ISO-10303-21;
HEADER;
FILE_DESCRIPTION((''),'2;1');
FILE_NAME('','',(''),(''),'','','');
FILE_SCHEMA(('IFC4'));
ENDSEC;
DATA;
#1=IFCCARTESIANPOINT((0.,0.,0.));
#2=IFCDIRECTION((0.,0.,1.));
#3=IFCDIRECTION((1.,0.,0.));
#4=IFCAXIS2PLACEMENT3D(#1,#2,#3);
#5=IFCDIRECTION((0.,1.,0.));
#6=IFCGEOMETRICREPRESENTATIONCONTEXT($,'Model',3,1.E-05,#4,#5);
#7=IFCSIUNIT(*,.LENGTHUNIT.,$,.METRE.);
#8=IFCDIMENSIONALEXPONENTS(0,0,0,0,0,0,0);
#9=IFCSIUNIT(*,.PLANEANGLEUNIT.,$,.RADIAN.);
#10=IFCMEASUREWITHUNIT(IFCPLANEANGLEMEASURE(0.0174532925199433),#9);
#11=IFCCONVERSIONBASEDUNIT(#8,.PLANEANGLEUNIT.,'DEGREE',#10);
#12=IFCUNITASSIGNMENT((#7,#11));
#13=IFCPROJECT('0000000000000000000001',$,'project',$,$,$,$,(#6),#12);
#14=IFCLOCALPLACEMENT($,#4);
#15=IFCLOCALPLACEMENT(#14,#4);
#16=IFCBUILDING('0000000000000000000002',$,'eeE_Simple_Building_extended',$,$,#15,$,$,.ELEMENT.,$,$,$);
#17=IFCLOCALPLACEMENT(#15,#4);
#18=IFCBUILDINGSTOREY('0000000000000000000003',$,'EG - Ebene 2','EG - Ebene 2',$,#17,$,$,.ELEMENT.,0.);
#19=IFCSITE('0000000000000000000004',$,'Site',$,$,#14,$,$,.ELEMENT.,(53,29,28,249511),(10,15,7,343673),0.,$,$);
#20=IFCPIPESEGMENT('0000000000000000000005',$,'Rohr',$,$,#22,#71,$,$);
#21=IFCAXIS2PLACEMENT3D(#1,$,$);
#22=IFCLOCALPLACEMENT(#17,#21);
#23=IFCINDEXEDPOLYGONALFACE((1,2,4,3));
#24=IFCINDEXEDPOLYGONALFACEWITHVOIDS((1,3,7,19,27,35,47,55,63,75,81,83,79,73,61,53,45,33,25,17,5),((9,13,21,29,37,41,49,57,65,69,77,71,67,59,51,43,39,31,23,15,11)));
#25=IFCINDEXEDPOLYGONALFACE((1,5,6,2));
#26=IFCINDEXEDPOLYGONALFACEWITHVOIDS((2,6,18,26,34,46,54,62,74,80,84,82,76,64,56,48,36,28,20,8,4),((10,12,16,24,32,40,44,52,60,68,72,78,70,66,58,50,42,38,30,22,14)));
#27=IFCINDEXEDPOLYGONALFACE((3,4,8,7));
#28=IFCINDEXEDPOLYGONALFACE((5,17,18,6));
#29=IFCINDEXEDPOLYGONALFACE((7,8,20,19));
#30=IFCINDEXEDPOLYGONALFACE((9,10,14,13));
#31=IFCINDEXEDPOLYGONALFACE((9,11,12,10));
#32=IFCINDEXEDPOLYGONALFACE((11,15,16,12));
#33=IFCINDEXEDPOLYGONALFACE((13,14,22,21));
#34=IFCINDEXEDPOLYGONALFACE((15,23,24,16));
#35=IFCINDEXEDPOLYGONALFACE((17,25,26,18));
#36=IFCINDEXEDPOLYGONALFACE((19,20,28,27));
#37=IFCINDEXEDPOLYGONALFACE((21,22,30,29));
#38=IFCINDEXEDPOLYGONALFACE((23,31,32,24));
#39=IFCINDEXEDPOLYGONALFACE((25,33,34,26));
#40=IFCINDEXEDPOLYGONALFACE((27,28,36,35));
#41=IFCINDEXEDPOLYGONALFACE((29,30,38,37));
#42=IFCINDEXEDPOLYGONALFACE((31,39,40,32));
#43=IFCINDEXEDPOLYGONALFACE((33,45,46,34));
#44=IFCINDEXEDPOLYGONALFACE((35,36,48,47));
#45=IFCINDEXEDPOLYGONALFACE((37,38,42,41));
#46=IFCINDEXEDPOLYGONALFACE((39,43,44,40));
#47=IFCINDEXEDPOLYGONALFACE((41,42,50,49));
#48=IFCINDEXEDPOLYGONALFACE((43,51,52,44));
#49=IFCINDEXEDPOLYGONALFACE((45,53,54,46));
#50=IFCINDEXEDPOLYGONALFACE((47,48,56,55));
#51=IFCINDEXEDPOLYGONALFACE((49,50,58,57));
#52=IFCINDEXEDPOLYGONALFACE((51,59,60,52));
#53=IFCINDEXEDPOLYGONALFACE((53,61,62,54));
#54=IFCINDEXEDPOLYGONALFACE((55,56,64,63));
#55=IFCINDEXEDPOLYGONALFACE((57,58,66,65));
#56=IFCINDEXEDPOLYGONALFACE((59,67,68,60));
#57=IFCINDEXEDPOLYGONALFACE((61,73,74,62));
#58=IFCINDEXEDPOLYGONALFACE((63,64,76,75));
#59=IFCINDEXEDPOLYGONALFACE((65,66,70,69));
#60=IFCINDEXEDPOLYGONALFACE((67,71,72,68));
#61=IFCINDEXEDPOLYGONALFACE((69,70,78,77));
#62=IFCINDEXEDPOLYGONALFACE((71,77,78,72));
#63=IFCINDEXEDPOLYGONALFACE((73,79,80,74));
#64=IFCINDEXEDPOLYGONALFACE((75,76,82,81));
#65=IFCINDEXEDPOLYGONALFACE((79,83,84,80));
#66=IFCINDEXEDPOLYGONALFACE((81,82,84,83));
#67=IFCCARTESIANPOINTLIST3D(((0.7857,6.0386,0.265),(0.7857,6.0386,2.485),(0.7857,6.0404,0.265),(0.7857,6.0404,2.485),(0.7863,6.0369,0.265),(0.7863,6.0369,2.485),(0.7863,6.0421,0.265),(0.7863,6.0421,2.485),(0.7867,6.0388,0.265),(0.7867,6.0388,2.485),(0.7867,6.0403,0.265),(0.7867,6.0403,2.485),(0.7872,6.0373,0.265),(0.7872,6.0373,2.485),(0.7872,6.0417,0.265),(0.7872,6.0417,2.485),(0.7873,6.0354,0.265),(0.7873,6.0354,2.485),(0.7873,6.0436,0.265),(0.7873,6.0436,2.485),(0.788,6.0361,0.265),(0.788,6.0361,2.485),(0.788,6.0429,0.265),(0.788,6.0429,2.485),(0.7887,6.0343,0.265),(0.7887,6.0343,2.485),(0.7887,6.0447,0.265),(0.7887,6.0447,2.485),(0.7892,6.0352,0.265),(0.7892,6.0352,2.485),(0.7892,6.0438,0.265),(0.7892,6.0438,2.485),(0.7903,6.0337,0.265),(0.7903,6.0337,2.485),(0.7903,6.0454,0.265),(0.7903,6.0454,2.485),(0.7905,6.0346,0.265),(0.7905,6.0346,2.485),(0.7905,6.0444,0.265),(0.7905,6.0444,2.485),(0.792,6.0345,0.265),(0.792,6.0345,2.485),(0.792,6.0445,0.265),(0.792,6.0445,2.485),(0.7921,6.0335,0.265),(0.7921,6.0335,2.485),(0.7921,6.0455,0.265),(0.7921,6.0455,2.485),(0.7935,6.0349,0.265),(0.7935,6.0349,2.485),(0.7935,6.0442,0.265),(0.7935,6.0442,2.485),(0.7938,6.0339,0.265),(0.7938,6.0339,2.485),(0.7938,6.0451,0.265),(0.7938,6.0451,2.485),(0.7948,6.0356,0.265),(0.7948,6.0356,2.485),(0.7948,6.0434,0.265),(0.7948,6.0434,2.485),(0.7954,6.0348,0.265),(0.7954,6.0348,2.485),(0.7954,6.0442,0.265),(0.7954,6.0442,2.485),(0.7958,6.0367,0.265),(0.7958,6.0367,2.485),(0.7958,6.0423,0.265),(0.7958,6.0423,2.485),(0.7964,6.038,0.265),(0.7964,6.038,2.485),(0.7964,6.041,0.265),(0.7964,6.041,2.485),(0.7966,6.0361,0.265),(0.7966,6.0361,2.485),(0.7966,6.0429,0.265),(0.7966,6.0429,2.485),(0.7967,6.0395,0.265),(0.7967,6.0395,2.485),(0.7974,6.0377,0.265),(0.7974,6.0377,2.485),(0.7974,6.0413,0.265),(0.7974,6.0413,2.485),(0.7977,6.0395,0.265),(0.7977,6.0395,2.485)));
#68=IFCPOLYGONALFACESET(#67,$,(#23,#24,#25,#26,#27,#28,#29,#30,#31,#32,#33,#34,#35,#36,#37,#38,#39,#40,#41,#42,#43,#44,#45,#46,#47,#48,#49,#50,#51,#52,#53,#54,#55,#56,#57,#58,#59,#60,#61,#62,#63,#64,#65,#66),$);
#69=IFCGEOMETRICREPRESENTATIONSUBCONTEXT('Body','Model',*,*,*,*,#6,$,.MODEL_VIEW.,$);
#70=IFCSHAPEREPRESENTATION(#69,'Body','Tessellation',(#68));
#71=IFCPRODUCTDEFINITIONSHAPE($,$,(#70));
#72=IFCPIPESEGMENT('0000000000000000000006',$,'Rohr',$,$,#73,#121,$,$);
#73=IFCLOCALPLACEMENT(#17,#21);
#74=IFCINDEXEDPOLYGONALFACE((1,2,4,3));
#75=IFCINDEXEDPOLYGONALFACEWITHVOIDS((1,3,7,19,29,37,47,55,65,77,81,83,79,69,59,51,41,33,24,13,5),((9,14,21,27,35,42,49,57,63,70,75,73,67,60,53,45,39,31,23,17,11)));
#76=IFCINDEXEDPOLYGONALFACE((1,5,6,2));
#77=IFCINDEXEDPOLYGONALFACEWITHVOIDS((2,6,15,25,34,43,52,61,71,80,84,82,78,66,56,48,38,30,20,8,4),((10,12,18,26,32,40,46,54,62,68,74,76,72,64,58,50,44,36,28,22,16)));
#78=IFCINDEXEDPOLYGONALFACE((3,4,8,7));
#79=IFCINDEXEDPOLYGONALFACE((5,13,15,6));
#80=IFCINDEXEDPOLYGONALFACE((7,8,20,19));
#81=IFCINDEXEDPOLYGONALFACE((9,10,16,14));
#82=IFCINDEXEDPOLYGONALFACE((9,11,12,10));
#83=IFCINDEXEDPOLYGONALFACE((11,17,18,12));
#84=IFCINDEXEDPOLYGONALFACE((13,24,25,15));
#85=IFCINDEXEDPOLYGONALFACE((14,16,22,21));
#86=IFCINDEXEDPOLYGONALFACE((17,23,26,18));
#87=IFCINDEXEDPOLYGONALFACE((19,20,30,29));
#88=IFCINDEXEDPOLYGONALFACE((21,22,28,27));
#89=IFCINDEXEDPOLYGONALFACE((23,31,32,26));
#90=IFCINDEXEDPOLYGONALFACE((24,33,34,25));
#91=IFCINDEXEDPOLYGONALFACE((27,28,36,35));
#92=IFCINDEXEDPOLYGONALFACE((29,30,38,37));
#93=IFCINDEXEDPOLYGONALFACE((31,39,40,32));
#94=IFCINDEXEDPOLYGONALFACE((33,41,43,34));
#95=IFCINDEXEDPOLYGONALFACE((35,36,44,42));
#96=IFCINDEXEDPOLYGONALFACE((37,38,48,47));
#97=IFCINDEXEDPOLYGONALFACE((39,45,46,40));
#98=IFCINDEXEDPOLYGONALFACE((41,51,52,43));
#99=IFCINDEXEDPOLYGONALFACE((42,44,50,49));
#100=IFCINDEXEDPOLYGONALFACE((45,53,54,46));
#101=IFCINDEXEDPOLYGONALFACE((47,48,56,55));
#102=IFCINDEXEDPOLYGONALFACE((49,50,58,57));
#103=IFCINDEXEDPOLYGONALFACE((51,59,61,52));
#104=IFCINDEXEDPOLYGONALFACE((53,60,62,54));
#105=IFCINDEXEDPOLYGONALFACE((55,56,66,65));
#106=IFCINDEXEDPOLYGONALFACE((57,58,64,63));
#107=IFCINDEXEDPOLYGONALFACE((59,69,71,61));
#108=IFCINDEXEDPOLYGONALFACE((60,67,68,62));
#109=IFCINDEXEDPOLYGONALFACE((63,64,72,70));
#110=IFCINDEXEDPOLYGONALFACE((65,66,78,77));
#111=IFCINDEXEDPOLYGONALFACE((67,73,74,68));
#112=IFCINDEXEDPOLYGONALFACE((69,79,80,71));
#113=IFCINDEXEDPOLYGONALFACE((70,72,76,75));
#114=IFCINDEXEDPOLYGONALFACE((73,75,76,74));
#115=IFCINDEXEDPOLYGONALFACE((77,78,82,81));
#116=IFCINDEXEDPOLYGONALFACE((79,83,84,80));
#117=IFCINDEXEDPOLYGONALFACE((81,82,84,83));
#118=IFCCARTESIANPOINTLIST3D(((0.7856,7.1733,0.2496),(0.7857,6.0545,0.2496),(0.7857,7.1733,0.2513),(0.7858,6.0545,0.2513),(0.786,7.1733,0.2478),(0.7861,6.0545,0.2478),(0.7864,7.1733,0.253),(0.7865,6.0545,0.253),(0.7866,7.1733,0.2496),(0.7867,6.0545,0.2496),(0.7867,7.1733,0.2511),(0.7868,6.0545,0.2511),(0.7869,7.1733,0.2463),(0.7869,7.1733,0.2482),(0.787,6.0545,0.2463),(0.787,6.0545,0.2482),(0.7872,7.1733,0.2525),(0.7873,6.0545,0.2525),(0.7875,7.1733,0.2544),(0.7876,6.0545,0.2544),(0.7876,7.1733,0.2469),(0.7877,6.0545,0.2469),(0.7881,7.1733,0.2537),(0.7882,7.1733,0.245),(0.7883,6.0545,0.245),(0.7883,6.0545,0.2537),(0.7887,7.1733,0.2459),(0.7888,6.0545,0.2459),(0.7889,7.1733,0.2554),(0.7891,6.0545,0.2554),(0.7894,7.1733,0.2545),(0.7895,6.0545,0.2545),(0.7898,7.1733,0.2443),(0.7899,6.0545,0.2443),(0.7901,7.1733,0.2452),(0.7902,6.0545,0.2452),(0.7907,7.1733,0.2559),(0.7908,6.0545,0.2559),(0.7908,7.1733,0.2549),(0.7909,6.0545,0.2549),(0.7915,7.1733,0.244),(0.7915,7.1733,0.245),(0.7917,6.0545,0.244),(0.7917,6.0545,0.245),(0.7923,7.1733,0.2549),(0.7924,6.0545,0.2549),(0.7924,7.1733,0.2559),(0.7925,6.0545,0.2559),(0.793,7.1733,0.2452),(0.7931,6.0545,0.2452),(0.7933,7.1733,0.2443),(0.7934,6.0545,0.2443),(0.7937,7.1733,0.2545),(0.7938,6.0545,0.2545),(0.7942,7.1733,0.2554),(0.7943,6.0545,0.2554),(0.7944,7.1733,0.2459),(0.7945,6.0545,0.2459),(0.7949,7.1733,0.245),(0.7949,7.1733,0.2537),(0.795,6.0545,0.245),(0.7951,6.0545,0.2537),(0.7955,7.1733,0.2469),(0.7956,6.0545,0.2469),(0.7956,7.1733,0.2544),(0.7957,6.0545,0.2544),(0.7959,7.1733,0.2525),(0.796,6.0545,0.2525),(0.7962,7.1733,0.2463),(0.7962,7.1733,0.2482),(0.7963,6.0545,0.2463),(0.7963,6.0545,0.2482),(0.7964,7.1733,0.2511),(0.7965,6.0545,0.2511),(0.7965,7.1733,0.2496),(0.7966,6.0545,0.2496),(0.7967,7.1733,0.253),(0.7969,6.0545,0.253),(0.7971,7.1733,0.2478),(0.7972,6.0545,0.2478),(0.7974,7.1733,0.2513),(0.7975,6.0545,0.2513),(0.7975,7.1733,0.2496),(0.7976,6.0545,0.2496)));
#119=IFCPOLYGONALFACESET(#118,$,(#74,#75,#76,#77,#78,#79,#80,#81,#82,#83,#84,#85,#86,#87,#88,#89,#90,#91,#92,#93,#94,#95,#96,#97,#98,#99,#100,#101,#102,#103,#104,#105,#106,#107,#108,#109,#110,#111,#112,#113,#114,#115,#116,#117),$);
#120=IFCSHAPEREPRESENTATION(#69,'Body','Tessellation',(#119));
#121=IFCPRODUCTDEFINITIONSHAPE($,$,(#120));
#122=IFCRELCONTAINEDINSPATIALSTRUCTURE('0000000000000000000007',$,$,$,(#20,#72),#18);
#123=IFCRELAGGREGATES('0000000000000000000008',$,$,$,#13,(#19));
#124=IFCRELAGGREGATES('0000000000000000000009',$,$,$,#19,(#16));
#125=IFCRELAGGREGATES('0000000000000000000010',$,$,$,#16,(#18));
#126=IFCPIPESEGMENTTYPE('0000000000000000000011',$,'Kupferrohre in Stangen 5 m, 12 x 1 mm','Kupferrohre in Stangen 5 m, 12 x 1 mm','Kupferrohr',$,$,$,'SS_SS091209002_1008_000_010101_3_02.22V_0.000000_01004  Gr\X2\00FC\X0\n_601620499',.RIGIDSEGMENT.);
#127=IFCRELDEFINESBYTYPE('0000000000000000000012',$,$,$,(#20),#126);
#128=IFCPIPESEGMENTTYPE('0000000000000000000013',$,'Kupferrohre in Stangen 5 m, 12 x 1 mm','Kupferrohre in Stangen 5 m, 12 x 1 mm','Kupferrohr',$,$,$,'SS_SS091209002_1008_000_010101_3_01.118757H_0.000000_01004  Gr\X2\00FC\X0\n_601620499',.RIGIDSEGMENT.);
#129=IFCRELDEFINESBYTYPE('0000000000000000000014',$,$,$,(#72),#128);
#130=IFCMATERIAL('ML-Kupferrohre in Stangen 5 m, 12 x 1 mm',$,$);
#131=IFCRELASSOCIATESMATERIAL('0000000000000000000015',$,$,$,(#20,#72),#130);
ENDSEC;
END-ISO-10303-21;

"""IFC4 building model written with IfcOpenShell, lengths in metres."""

from ifc_helpers import new_model, entity, si_unit, converted_unit, direction, frame, origin_with_axes, origin_2d_with_axis, place, context, subcontext, project, spatial, hollow_circle, extrude, material, type_object, element, save


model = new_model("IFC4")

# Units and contexts
model_context = context("Model", 3, precision=1e-05, world=origin_with_axes(), true_north=direction((0.0, 1.0, 0.0)))
body_context = subcontext(model_context, "Body", "Model", "MODEL_VIEW")
ifc_project = project(units=[si_unit("LENGTHUNIT", "METRE"), converted_unit("PLANEANGLEUNIT", "DEGREE", entity("IfcPlaneAngleMeasure", 0.0174532925199433), si_unit("PLANEANGLEUNIT", "RADIAN"), dimensions=[0, 0, 0, 0, 0, 0, 0])], contexts=[model_context])

# Site, building, storey
site_placement = place(None, origin_with_axes())
site = spatial("IfcSite", under=ifc_project, at=site_placement, Name="Site", CompositionType="ELEMENT", RefLatitude=(53, 29, 28, 249511), RefLongitude=(10, 15, 7, 343673), RefElevation=0.0)
building_placement = place(site_placement, origin_with_axes())
building = spatial("IfcBuilding", under=site, at=building_placement, Name="eeE_Simple_Building_extended", CompositionType="ELEMENT")
storey_placement = place(building_placement, origin_with_axes())
storey = spatial("IfcBuildingStorey", under=building, at=storey_placement, Name="EG - Ebene 2", Description="EG - Ebene 2", CompositionType="ELEMENT", Elevation=0.0)

# Pipe segments
ifc_material_1 = material(Name="ML-Kupferrohre in Stangen 5 m, 12 x 1 mm")
pipe_segment_type_1 = type_object("IfcPipeSegmentType", Name="Kupferrohre in Stangen 5 m, 12 x 1 mm", Description="Kupferrohre in Stangen 5 m, 12 x 1 mm", ApplicableOccurrence="Kupferrohr", ElementType="SS_SS091209002_1008_000_010101_3_02.22V_0.000000_01004  Grün_601620499", PredefinedType="RIGIDSEGMENT")
pipe_segment_1_placement = place(storey_placement, frame((0.7917, 6.0395, 2.485), z_axis=(-1.0, 0.0, 0.0), x_axis=(0.0, 0.0, -1.0)))
element("IfcPipeSegment", 1, at=pipe_segment_1_placement, inside=storey, type_object=pipe_segment_type_1, material=ifc_material_1, Name="Rohr", context=body_context, shape_type="SweptSolid", body=[
    extrude(hollow_circle(Radius=0.006, WallThickness=0.001, at=origin_2d_with_axis()), frame((0.0, 0.0, 0.0), z_axis=(1.0, 0.0, 0.0), x_axis=(0.0, 0.0, -1.0)), (0.0, 0.0, 1.0), 2.22),
])
pipe_segment_type_2 = type_object("IfcPipeSegmentType", Name="Kupferrohre in Stangen 5 m, 12 x 1 mm", Description="Kupferrohre in Stangen 5 m, 12 x 1 mm", ApplicableOccurrence="Kupferrohr", ElementType="SS_SS091209002_1008_000_010101_3_01.118757H_0.000000_01004  Grün_601620499", PredefinedType="RIGIDSEGMENT")
pipe_segment_2_placement = place(storey_placement, frame((0.7917, 6.0545, 0.25), z_axis=(0.0, 0.0, 1.0), x_axis=(-0.000096, 1.0, 0.0)))
element("IfcPipeSegment", 2, at=pipe_segment_2_placement, inside=storey, type_object=pipe_segment_type_2, material=ifc_material_1, Name="Rohr", context=body_context, shape_type="SweptSolid", body=[
    extrude(hollow_circle(Radius=0.006, WallThickness=0.001, at=origin_2d_with_axis()), frame((0.0, 0.0, 0.0), z_axis=(1.0, 0.0, 0.0), x_axis=(0.0, 0.0, -1.0)), (0.0, 0.0, 1.0), 1.1188),
])

save(model, "model.ifc")
